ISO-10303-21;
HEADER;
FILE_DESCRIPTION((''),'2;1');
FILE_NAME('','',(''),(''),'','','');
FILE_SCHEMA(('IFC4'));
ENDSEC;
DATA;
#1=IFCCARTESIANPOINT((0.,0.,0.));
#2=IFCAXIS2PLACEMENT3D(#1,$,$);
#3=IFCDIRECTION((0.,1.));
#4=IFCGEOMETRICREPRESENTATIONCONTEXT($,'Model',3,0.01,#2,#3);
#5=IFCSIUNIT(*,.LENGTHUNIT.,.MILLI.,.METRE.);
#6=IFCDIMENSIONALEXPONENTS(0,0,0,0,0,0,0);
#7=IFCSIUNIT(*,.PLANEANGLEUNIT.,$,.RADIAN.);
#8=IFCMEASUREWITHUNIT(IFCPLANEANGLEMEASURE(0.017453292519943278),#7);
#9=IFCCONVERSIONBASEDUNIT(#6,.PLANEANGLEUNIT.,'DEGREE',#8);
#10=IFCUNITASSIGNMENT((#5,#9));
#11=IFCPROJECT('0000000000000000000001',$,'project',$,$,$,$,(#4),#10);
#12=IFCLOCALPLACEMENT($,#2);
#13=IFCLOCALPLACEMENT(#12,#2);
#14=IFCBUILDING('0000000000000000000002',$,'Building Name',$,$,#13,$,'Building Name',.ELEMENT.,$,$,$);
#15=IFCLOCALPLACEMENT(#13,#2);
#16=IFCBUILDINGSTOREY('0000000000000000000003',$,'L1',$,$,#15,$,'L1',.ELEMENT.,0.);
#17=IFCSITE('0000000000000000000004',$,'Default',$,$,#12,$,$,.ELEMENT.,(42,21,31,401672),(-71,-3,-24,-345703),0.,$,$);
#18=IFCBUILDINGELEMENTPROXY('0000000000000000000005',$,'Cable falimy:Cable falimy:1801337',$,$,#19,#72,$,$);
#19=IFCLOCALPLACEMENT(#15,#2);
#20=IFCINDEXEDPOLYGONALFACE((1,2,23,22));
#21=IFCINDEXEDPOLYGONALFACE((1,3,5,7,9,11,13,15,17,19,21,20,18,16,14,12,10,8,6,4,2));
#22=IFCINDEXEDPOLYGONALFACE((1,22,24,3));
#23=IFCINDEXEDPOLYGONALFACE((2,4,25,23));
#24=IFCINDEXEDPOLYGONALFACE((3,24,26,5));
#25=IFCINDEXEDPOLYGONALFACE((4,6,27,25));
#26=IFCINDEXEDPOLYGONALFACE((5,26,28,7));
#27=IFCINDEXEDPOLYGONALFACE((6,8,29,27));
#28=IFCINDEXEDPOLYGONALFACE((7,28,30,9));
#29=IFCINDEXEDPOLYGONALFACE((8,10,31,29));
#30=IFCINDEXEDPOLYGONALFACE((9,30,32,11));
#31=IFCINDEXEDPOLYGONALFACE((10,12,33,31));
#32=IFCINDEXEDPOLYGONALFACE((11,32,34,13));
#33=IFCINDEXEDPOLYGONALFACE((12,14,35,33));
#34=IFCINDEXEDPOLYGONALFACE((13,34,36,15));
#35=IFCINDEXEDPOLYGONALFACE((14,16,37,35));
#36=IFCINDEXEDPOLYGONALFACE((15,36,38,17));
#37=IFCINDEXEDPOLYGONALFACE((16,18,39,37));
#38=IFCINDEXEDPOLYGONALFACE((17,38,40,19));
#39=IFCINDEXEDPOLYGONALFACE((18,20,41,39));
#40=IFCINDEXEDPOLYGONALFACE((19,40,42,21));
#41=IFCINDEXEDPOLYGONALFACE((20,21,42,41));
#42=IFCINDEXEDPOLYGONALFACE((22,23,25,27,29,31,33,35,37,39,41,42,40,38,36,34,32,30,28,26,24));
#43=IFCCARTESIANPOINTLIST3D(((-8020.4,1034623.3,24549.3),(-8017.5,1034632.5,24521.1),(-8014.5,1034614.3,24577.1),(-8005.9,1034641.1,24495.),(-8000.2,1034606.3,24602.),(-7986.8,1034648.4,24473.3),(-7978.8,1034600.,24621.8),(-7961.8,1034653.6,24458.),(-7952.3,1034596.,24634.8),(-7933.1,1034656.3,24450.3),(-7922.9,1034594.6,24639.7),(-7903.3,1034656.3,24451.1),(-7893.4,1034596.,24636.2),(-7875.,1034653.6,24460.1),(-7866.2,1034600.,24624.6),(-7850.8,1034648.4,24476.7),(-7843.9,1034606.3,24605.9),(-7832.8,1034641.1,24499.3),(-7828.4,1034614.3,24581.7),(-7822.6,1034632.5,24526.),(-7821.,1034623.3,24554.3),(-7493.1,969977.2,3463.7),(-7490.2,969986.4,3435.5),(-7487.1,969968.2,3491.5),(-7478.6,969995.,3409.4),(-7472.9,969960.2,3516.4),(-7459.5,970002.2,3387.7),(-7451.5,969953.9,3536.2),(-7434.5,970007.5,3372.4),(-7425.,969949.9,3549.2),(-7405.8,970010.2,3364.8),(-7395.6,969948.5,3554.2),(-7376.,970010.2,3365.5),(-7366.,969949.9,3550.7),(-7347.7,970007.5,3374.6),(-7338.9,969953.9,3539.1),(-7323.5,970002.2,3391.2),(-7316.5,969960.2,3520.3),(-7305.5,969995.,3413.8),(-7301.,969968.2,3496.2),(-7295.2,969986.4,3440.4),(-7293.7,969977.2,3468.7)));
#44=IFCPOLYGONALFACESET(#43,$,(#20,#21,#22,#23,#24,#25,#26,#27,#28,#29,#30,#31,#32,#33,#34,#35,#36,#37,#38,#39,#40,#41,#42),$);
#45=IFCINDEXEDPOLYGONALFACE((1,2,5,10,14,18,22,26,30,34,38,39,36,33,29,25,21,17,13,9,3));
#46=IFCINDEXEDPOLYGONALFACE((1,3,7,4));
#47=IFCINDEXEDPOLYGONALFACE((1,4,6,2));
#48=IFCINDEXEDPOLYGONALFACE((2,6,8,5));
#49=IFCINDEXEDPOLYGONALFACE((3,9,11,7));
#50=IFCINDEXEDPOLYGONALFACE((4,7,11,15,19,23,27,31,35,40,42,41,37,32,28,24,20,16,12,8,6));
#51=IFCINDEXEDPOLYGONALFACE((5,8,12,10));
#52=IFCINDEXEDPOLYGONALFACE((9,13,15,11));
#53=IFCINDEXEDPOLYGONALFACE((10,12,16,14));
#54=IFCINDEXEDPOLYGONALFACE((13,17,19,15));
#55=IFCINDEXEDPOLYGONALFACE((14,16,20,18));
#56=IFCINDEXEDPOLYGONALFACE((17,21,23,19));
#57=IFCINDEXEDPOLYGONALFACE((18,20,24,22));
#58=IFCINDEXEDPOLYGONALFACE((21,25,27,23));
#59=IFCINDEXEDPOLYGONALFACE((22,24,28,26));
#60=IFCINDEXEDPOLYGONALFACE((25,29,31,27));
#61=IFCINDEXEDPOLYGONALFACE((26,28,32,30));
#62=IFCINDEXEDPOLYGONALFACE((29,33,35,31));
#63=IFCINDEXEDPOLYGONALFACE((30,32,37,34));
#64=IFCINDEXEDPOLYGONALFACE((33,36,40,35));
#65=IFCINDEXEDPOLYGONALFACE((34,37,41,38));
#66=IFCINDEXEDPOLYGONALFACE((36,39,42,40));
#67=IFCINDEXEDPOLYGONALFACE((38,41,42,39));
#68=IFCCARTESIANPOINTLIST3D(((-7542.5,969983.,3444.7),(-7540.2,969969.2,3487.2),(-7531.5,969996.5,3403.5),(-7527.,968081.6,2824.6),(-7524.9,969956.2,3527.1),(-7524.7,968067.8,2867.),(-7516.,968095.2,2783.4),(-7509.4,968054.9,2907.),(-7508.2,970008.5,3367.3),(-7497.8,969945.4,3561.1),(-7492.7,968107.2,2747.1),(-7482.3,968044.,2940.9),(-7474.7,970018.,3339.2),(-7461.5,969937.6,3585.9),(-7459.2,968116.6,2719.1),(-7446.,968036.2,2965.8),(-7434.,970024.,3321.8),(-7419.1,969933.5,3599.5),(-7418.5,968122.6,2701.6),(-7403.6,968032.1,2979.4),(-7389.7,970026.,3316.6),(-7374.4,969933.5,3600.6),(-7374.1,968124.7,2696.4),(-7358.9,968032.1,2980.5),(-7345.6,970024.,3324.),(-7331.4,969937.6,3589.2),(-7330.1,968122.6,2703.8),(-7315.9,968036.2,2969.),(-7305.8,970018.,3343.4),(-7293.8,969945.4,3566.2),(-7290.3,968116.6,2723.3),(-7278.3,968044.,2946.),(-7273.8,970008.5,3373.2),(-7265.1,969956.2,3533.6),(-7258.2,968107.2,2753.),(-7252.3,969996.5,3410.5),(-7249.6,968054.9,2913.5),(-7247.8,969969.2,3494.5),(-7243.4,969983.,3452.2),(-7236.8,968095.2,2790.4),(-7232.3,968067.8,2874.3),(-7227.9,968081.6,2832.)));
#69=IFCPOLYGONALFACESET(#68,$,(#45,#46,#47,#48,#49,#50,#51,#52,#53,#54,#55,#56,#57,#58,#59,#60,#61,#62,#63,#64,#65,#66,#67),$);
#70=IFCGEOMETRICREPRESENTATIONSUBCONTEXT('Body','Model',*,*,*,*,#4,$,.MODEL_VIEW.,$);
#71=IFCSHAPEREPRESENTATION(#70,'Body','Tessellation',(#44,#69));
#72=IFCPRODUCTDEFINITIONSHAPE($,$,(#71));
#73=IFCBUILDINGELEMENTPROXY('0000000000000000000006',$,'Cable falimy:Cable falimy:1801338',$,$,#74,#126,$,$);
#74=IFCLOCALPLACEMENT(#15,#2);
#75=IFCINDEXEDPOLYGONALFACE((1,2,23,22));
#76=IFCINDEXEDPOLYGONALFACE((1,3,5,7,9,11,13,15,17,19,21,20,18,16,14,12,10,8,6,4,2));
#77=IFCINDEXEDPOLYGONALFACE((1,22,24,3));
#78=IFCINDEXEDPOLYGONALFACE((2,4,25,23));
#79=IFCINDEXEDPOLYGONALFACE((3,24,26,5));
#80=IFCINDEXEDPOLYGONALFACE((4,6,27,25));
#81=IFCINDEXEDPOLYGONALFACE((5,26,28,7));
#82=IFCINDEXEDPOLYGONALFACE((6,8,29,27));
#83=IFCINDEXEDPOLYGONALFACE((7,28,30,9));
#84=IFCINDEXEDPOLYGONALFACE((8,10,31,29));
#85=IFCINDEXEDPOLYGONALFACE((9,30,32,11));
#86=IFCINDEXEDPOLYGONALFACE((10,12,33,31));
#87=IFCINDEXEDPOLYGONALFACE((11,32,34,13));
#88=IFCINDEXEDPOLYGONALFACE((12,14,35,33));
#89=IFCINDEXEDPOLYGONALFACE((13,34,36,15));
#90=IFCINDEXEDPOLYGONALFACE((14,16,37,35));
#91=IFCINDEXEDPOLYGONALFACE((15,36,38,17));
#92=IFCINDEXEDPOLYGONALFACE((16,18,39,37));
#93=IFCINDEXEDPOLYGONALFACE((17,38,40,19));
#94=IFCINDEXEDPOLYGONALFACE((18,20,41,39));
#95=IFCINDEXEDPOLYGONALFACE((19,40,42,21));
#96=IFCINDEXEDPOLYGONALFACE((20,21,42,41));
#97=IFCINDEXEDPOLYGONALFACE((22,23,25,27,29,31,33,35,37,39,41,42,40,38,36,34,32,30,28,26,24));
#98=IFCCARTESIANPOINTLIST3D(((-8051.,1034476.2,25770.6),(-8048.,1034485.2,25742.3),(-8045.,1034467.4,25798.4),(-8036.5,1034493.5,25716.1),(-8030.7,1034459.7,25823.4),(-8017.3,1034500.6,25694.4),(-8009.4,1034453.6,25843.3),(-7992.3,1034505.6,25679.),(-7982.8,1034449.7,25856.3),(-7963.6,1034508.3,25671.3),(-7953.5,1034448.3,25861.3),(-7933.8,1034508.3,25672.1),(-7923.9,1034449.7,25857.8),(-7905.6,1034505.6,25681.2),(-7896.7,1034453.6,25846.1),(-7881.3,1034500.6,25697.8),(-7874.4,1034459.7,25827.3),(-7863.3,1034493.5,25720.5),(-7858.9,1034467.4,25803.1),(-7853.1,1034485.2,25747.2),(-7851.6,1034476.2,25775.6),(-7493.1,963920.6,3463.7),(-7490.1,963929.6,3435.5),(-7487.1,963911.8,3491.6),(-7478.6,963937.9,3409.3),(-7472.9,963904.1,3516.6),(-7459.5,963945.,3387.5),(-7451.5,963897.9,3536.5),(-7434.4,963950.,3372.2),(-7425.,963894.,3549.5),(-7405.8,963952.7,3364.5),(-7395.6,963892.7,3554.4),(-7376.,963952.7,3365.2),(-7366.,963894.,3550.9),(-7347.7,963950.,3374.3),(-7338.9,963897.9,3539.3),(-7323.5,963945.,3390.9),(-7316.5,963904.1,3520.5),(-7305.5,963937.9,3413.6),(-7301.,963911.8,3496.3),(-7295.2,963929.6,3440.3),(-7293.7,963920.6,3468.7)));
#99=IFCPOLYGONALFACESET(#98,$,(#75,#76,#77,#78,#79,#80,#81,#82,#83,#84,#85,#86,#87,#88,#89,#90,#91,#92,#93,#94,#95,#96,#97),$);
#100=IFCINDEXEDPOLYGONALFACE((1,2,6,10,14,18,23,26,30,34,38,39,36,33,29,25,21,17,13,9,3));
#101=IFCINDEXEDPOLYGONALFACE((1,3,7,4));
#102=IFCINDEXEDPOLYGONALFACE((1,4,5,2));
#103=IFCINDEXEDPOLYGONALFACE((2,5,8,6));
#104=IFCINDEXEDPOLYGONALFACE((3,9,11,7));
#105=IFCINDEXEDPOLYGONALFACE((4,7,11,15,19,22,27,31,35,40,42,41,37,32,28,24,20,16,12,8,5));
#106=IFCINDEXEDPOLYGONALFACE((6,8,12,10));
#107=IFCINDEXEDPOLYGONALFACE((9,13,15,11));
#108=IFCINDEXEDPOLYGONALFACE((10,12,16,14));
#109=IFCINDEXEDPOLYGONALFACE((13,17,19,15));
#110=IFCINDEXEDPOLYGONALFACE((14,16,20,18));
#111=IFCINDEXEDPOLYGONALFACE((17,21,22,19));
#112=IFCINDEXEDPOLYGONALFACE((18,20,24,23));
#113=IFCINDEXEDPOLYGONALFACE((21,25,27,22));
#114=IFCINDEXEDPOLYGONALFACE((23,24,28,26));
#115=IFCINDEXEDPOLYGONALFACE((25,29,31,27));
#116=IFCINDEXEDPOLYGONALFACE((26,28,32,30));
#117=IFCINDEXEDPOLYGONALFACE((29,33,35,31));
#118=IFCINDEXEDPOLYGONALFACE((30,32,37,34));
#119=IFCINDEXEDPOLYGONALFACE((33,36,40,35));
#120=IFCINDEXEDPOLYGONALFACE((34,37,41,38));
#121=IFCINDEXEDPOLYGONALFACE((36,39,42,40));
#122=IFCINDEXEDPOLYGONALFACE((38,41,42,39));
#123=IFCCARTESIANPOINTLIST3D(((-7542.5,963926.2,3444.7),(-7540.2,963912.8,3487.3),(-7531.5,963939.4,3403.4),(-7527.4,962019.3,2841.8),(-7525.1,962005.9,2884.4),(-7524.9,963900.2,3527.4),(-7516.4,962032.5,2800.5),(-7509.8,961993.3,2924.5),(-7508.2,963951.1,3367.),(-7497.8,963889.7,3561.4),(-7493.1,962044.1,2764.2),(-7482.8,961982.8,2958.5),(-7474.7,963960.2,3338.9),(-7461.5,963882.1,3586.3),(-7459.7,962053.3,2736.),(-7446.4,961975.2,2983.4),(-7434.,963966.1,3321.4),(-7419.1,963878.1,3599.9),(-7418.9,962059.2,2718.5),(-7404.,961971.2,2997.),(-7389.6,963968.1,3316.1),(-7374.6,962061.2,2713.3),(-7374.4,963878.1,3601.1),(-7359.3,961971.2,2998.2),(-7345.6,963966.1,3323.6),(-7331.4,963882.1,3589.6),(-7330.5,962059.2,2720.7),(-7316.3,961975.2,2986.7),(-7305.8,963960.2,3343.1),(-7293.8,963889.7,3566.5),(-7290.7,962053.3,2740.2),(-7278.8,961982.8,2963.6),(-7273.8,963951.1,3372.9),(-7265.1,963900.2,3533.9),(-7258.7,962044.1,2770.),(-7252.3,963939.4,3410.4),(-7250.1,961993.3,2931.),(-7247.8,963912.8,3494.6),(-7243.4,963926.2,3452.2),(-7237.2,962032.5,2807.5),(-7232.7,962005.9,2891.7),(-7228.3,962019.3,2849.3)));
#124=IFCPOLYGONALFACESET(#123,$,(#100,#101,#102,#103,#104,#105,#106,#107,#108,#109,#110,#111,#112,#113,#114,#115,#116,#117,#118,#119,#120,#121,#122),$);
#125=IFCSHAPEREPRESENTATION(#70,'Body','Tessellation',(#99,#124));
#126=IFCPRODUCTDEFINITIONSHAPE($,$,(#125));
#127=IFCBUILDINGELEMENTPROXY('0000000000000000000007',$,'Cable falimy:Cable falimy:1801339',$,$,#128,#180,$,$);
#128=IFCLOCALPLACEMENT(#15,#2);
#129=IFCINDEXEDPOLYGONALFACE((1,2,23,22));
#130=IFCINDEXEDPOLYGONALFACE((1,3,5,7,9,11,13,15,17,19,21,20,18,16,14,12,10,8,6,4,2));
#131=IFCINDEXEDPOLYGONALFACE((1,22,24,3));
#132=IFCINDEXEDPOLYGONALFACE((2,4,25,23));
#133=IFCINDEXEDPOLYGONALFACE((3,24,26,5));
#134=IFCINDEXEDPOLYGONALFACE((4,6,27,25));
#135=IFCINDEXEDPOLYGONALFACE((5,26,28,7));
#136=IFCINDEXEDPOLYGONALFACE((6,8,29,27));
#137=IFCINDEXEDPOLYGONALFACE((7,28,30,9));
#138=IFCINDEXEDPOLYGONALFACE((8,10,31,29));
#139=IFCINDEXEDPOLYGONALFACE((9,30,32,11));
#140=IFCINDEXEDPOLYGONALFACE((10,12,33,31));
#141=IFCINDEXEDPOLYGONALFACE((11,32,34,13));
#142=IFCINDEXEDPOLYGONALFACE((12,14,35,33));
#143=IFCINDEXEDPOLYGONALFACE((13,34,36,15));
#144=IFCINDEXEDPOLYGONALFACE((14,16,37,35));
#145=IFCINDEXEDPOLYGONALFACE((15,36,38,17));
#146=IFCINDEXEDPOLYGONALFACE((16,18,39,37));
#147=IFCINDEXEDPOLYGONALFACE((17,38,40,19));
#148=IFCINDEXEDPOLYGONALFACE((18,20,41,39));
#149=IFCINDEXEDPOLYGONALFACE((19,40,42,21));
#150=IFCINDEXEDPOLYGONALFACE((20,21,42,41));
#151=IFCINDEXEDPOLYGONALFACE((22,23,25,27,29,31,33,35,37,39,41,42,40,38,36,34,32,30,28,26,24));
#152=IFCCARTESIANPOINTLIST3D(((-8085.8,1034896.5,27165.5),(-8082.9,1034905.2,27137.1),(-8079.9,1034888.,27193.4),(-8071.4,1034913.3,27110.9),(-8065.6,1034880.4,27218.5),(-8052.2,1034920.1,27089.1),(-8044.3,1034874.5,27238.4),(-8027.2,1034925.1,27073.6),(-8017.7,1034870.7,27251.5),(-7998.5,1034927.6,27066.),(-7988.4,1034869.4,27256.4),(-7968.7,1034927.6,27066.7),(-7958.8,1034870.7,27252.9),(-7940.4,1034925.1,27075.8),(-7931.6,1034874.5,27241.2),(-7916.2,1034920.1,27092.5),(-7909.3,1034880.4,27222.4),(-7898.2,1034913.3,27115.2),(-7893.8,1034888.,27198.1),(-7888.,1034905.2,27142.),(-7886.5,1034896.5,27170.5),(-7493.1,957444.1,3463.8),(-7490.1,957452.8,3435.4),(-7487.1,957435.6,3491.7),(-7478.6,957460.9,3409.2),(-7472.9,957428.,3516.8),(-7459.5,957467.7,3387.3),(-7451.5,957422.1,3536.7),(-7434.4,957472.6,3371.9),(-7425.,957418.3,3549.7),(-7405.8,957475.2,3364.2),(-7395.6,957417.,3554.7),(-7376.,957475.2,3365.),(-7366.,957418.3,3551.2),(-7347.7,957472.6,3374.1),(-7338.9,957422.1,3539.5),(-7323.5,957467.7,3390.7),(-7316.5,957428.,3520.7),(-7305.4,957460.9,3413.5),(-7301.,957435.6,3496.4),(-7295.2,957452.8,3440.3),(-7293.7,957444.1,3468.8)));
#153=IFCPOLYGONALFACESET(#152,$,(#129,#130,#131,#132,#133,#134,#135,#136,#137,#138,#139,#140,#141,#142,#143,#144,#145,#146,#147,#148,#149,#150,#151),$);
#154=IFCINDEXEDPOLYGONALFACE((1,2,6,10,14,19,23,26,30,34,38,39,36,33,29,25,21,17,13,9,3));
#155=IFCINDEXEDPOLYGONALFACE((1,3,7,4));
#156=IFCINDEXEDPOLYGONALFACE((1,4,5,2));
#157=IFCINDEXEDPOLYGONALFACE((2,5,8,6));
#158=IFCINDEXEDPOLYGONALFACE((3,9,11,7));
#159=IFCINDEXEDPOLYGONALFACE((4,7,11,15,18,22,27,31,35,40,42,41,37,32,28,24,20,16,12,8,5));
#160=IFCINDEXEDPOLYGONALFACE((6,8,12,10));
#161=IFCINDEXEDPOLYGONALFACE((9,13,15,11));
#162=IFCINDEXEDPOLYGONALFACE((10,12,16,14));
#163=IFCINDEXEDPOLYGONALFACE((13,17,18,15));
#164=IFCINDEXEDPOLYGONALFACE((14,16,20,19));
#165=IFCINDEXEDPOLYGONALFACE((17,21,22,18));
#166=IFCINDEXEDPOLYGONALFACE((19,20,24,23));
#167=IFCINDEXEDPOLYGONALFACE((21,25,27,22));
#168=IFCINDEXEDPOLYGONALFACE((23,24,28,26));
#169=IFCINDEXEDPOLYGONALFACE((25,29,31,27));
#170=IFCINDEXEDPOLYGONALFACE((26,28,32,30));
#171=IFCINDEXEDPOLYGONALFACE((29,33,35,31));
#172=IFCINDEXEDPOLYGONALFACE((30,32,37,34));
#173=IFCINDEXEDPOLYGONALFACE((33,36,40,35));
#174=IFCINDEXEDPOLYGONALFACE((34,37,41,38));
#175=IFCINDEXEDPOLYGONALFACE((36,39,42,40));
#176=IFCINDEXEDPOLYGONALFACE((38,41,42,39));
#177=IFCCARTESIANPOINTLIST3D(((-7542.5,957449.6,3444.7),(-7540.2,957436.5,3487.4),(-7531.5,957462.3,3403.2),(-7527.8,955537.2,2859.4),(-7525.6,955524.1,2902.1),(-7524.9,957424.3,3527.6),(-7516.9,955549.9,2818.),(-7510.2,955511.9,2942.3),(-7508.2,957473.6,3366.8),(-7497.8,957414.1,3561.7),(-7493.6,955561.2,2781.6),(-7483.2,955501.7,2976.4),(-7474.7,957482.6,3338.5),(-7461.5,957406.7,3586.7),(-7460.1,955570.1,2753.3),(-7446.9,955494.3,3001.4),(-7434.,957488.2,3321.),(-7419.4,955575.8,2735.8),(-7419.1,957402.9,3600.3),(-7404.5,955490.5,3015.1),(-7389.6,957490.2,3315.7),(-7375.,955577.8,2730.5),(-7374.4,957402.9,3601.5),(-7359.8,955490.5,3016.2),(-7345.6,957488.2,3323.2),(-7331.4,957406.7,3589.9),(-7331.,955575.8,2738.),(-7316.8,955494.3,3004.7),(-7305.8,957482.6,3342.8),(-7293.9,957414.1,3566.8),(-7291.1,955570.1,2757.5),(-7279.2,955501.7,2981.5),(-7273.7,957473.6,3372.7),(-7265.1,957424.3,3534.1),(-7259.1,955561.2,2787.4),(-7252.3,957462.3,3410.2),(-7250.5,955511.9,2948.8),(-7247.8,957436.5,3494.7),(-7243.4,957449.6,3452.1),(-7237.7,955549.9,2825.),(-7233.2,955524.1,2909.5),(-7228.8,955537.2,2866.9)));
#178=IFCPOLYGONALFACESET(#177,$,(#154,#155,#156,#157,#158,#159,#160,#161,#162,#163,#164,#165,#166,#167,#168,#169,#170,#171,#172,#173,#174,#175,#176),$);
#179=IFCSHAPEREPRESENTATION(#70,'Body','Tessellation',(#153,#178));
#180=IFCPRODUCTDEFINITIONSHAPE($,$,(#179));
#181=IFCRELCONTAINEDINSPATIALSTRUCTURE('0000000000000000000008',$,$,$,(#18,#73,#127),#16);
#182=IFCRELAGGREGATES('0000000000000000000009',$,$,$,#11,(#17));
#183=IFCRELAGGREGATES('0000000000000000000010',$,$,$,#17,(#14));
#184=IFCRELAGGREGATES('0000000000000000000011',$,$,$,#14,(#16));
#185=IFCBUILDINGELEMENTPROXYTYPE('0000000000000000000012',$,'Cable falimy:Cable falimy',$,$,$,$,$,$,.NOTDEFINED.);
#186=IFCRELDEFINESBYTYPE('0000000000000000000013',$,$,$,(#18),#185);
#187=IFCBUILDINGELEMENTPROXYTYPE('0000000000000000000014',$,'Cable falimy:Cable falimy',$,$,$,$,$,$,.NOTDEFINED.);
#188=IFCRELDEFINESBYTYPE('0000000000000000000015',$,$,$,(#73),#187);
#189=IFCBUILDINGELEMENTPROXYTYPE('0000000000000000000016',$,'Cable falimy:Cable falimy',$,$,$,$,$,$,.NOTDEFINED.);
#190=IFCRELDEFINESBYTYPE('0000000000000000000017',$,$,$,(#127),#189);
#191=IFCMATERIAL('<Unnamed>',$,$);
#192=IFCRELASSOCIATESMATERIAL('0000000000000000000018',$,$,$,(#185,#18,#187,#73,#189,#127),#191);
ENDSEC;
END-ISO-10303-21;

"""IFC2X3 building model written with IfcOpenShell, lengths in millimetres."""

from ifc_helpers import new_model, entity, si_unit, converted_unit, direction, frame, frame_2d, origin, place, context, subcontext, project, spatial, circle, extrude, source, transform, mapped, material, type_object, type_shapes, element, save


model = new_model("IFC2X3")

# Units and contexts
model_context = context("Model", 3, precision=0.01, world=origin(), true_north=direction((0.0, 1.0)))
body_context = subcontext(model_context, "Body", "Model", "MODEL_VIEW")
ifc_project = project(units=[si_unit("LENGTHUNIT", "METRE", prefix="MILLI"), converted_unit("PLANEANGLEUNIT", "DEGREE", entity("IfcPlaneAngleMeasure", 0.017453292519943278), si_unit("PLANEANGLEUNIT", "RADIAN"), dimensions=[0, 0, 0, 0, 0, 0, 0])], contexts=[model_context])

# Site, building, storey
site_placement = place(None, origin())
site = spatial("IfcSite", under=ifc_project, at=site_placement, Name="Default", CompositionType="ELEMENT", RefLatitude=(42, 21, 31, 401672), RefLongitude=(-71, -3, -24, -345703), RefElevation=0.0)
building_placement = place(site_placement, origin())
building = spatial("IfcBuilding", under=site, at=building_placement, Name="Building Name", LongName="Building Name", CompositionType="ELEMENT")
storey_placement = place(building_placement, origin())
storey = spatial("IfcBuildingStorey", under=building, at=storey_placement, Name="L1", LongName="L1", CompositionType="ELEMENT", Elevation=0.0)

# Shared definitions
ifc_material = material(Name="<Unnamed>")

# Building element proxies
building_element_proxy_type_1 = type_object("IfcBuildingElementProxyType", Name="Cable falimy:Cable falimy", PredefinedType="NOTDEFINED", material=ifc_material)
shared_shape_1 = source(origin(), body_context, "Body", "SweptSolid", [
    extrude(circle(Radius=100.0, at=frame_2d((0.0, 0.0), x_axis=(1.0, 0.0))), frame((0.0, 0.0, 0.0), z_axis=(0.950678, 0.0, 0.310179), x_axis=(-0.310179, 0.0, 0.950678)), (0.0, 0.0, 1.0), 68000.0),
    extrude(circle(Radius=150.0, at=frame_2d((0.0, 0.0), x_axis=(1.0, 0.0))), frame((-1901.4, 0.0, -620.4), z_axis=(0.950678, 0.0, 0.310179), x_axis=(0.310179, 0.0, -0.950678)), (0.0, 0.0, 1.0), 2000.0),
])
type_shapes(building_element_proxy_type_1, [shared_shape_1])
proxy_1_placement = place(storey_placement, frame((-7393.2, 969979.5, 3459.1), z_axis=(-0.025001, 0.0, 0.999687), x_axis=(0.0, 1.0, 0.0)))
element("IfcBuildingElementProxy", 1, at=proxy_1_placement, inside=storey, type_object=building_element_proxy_type_1, material=ifc_material, Name="Cable falimy:Cable falimy:1801337", context=body_context, shape_type="MappedRepresentation", body=[
    mapped(shared_shape_1, transform((0.0, 0.0, 0.0), scale=1.0)),
])
building_element_proxy_type_2 = type_object("IfcBuildingElementProxyType", Name="Cable falimy:Cable falimy", PredefinedType="NOTDEFINED", material=ifc_material)
shared_shape_2 = source(origin(), body_context, "Body", "SweptSolid", [
    extrude(circle(Radius=100.0, at=frame_2d((0.0, 0.0), x_axis=(1.0, 0.0))), frame((0.0, 0.0, 0.0), z_axis=(0.953454, 0.0, 0.301538), x_axis=(-0.301538, 0.0, 0.953454)), (0.0, 0.0, 1.0), 74000.0),
    extrude(circle(Radius=150.0, at=frame_2d((0.0, 0.0), x_axis=(1.0, 0.0))), frame((-1906.9, 0.0, -603.1), z_axis=(0.953454, 0.0, 0.301538), x_axis=(0.301538, 0.0, -0.953454)), (0.0, 0.0, 1.0), 2000.0),
])
type_shapes(building_element_proxy_type_2, [shared_shape_2])
proxy_2_placement = place(storey_placement, frame((-7393.2, 963922.9, 3459.1), z_axis=(-0.025001, 0.0, 0.999687), x_axis=(0.0, 1.0, 0.0)))
element("IfcBuildingElementProxy", 2, at=proxy_2_placement, inside=storey, type_object=building_element_proxy_type_2, material=ifc_material, Name="Cable falimy:Cable falimy:1801338", context=body_context, shape_type="MappedRepresentation", body=[
    mapped(shared_shape_2, transform((0.0, 0.0, 0.0), scale=1.0)),
])
building_element_proxy_type_3 = type_object("IfcBuildingElementProxyType", Name="Cable falimy:Cable falimy", PredefinedType="NOTDEFINED", material=ifc_material)
shared_shape_3 = source(origin(), body_context, "Body", "SweptSolid", [
    extrude(circle(Radius=100.0, at=frame_2d((0.0, 0.0), x_axis=(1.0, 0.0))), frame((0.0, 0.0, 0.0), z_axis=(0.956203, 0.0, 0.292706), x_axis=(-0.292706, 0.0, 0.956203)), (0.0, 0.0, 1.0), 81000.0),
    extrude(circle(Radius=150.0, at=frame_2d((0.0, 0.0), x_axis=(1.0, 0.0))), frame((-1912.4, 0.0, -585.4), z_axis=(0.956203, 0.0, 0.292706), x_axis=(0.292706, 0.0, -0.956203)), (0.0, 0.0, 1.0), 2000.0),
])
type_shapes(building_element_proxy_type_3, [shared_shape_3])
proxy_3_placement = place(storey_placement, frame((-7393.2, 957446.3, 3459.1), z_axis=(-0.025001, 0.0, 0.999687), x_axis=(0.0, 1.0, 0.0)))
element("IfcBuildingElementProxy", 3, at=proxy_3_placement, inside=storey, type_object=building_element_proxy_type_3, material=ifc_material, Name="Cable falimy:Cable falimy:1801339", context=body_context, shape_type="MappedRepresentation", body=[
    mapped(shared_shape_3, transform((0.0, 0.0, 0.0), scale=1.0)),
])

save(model, "model.ifc")
